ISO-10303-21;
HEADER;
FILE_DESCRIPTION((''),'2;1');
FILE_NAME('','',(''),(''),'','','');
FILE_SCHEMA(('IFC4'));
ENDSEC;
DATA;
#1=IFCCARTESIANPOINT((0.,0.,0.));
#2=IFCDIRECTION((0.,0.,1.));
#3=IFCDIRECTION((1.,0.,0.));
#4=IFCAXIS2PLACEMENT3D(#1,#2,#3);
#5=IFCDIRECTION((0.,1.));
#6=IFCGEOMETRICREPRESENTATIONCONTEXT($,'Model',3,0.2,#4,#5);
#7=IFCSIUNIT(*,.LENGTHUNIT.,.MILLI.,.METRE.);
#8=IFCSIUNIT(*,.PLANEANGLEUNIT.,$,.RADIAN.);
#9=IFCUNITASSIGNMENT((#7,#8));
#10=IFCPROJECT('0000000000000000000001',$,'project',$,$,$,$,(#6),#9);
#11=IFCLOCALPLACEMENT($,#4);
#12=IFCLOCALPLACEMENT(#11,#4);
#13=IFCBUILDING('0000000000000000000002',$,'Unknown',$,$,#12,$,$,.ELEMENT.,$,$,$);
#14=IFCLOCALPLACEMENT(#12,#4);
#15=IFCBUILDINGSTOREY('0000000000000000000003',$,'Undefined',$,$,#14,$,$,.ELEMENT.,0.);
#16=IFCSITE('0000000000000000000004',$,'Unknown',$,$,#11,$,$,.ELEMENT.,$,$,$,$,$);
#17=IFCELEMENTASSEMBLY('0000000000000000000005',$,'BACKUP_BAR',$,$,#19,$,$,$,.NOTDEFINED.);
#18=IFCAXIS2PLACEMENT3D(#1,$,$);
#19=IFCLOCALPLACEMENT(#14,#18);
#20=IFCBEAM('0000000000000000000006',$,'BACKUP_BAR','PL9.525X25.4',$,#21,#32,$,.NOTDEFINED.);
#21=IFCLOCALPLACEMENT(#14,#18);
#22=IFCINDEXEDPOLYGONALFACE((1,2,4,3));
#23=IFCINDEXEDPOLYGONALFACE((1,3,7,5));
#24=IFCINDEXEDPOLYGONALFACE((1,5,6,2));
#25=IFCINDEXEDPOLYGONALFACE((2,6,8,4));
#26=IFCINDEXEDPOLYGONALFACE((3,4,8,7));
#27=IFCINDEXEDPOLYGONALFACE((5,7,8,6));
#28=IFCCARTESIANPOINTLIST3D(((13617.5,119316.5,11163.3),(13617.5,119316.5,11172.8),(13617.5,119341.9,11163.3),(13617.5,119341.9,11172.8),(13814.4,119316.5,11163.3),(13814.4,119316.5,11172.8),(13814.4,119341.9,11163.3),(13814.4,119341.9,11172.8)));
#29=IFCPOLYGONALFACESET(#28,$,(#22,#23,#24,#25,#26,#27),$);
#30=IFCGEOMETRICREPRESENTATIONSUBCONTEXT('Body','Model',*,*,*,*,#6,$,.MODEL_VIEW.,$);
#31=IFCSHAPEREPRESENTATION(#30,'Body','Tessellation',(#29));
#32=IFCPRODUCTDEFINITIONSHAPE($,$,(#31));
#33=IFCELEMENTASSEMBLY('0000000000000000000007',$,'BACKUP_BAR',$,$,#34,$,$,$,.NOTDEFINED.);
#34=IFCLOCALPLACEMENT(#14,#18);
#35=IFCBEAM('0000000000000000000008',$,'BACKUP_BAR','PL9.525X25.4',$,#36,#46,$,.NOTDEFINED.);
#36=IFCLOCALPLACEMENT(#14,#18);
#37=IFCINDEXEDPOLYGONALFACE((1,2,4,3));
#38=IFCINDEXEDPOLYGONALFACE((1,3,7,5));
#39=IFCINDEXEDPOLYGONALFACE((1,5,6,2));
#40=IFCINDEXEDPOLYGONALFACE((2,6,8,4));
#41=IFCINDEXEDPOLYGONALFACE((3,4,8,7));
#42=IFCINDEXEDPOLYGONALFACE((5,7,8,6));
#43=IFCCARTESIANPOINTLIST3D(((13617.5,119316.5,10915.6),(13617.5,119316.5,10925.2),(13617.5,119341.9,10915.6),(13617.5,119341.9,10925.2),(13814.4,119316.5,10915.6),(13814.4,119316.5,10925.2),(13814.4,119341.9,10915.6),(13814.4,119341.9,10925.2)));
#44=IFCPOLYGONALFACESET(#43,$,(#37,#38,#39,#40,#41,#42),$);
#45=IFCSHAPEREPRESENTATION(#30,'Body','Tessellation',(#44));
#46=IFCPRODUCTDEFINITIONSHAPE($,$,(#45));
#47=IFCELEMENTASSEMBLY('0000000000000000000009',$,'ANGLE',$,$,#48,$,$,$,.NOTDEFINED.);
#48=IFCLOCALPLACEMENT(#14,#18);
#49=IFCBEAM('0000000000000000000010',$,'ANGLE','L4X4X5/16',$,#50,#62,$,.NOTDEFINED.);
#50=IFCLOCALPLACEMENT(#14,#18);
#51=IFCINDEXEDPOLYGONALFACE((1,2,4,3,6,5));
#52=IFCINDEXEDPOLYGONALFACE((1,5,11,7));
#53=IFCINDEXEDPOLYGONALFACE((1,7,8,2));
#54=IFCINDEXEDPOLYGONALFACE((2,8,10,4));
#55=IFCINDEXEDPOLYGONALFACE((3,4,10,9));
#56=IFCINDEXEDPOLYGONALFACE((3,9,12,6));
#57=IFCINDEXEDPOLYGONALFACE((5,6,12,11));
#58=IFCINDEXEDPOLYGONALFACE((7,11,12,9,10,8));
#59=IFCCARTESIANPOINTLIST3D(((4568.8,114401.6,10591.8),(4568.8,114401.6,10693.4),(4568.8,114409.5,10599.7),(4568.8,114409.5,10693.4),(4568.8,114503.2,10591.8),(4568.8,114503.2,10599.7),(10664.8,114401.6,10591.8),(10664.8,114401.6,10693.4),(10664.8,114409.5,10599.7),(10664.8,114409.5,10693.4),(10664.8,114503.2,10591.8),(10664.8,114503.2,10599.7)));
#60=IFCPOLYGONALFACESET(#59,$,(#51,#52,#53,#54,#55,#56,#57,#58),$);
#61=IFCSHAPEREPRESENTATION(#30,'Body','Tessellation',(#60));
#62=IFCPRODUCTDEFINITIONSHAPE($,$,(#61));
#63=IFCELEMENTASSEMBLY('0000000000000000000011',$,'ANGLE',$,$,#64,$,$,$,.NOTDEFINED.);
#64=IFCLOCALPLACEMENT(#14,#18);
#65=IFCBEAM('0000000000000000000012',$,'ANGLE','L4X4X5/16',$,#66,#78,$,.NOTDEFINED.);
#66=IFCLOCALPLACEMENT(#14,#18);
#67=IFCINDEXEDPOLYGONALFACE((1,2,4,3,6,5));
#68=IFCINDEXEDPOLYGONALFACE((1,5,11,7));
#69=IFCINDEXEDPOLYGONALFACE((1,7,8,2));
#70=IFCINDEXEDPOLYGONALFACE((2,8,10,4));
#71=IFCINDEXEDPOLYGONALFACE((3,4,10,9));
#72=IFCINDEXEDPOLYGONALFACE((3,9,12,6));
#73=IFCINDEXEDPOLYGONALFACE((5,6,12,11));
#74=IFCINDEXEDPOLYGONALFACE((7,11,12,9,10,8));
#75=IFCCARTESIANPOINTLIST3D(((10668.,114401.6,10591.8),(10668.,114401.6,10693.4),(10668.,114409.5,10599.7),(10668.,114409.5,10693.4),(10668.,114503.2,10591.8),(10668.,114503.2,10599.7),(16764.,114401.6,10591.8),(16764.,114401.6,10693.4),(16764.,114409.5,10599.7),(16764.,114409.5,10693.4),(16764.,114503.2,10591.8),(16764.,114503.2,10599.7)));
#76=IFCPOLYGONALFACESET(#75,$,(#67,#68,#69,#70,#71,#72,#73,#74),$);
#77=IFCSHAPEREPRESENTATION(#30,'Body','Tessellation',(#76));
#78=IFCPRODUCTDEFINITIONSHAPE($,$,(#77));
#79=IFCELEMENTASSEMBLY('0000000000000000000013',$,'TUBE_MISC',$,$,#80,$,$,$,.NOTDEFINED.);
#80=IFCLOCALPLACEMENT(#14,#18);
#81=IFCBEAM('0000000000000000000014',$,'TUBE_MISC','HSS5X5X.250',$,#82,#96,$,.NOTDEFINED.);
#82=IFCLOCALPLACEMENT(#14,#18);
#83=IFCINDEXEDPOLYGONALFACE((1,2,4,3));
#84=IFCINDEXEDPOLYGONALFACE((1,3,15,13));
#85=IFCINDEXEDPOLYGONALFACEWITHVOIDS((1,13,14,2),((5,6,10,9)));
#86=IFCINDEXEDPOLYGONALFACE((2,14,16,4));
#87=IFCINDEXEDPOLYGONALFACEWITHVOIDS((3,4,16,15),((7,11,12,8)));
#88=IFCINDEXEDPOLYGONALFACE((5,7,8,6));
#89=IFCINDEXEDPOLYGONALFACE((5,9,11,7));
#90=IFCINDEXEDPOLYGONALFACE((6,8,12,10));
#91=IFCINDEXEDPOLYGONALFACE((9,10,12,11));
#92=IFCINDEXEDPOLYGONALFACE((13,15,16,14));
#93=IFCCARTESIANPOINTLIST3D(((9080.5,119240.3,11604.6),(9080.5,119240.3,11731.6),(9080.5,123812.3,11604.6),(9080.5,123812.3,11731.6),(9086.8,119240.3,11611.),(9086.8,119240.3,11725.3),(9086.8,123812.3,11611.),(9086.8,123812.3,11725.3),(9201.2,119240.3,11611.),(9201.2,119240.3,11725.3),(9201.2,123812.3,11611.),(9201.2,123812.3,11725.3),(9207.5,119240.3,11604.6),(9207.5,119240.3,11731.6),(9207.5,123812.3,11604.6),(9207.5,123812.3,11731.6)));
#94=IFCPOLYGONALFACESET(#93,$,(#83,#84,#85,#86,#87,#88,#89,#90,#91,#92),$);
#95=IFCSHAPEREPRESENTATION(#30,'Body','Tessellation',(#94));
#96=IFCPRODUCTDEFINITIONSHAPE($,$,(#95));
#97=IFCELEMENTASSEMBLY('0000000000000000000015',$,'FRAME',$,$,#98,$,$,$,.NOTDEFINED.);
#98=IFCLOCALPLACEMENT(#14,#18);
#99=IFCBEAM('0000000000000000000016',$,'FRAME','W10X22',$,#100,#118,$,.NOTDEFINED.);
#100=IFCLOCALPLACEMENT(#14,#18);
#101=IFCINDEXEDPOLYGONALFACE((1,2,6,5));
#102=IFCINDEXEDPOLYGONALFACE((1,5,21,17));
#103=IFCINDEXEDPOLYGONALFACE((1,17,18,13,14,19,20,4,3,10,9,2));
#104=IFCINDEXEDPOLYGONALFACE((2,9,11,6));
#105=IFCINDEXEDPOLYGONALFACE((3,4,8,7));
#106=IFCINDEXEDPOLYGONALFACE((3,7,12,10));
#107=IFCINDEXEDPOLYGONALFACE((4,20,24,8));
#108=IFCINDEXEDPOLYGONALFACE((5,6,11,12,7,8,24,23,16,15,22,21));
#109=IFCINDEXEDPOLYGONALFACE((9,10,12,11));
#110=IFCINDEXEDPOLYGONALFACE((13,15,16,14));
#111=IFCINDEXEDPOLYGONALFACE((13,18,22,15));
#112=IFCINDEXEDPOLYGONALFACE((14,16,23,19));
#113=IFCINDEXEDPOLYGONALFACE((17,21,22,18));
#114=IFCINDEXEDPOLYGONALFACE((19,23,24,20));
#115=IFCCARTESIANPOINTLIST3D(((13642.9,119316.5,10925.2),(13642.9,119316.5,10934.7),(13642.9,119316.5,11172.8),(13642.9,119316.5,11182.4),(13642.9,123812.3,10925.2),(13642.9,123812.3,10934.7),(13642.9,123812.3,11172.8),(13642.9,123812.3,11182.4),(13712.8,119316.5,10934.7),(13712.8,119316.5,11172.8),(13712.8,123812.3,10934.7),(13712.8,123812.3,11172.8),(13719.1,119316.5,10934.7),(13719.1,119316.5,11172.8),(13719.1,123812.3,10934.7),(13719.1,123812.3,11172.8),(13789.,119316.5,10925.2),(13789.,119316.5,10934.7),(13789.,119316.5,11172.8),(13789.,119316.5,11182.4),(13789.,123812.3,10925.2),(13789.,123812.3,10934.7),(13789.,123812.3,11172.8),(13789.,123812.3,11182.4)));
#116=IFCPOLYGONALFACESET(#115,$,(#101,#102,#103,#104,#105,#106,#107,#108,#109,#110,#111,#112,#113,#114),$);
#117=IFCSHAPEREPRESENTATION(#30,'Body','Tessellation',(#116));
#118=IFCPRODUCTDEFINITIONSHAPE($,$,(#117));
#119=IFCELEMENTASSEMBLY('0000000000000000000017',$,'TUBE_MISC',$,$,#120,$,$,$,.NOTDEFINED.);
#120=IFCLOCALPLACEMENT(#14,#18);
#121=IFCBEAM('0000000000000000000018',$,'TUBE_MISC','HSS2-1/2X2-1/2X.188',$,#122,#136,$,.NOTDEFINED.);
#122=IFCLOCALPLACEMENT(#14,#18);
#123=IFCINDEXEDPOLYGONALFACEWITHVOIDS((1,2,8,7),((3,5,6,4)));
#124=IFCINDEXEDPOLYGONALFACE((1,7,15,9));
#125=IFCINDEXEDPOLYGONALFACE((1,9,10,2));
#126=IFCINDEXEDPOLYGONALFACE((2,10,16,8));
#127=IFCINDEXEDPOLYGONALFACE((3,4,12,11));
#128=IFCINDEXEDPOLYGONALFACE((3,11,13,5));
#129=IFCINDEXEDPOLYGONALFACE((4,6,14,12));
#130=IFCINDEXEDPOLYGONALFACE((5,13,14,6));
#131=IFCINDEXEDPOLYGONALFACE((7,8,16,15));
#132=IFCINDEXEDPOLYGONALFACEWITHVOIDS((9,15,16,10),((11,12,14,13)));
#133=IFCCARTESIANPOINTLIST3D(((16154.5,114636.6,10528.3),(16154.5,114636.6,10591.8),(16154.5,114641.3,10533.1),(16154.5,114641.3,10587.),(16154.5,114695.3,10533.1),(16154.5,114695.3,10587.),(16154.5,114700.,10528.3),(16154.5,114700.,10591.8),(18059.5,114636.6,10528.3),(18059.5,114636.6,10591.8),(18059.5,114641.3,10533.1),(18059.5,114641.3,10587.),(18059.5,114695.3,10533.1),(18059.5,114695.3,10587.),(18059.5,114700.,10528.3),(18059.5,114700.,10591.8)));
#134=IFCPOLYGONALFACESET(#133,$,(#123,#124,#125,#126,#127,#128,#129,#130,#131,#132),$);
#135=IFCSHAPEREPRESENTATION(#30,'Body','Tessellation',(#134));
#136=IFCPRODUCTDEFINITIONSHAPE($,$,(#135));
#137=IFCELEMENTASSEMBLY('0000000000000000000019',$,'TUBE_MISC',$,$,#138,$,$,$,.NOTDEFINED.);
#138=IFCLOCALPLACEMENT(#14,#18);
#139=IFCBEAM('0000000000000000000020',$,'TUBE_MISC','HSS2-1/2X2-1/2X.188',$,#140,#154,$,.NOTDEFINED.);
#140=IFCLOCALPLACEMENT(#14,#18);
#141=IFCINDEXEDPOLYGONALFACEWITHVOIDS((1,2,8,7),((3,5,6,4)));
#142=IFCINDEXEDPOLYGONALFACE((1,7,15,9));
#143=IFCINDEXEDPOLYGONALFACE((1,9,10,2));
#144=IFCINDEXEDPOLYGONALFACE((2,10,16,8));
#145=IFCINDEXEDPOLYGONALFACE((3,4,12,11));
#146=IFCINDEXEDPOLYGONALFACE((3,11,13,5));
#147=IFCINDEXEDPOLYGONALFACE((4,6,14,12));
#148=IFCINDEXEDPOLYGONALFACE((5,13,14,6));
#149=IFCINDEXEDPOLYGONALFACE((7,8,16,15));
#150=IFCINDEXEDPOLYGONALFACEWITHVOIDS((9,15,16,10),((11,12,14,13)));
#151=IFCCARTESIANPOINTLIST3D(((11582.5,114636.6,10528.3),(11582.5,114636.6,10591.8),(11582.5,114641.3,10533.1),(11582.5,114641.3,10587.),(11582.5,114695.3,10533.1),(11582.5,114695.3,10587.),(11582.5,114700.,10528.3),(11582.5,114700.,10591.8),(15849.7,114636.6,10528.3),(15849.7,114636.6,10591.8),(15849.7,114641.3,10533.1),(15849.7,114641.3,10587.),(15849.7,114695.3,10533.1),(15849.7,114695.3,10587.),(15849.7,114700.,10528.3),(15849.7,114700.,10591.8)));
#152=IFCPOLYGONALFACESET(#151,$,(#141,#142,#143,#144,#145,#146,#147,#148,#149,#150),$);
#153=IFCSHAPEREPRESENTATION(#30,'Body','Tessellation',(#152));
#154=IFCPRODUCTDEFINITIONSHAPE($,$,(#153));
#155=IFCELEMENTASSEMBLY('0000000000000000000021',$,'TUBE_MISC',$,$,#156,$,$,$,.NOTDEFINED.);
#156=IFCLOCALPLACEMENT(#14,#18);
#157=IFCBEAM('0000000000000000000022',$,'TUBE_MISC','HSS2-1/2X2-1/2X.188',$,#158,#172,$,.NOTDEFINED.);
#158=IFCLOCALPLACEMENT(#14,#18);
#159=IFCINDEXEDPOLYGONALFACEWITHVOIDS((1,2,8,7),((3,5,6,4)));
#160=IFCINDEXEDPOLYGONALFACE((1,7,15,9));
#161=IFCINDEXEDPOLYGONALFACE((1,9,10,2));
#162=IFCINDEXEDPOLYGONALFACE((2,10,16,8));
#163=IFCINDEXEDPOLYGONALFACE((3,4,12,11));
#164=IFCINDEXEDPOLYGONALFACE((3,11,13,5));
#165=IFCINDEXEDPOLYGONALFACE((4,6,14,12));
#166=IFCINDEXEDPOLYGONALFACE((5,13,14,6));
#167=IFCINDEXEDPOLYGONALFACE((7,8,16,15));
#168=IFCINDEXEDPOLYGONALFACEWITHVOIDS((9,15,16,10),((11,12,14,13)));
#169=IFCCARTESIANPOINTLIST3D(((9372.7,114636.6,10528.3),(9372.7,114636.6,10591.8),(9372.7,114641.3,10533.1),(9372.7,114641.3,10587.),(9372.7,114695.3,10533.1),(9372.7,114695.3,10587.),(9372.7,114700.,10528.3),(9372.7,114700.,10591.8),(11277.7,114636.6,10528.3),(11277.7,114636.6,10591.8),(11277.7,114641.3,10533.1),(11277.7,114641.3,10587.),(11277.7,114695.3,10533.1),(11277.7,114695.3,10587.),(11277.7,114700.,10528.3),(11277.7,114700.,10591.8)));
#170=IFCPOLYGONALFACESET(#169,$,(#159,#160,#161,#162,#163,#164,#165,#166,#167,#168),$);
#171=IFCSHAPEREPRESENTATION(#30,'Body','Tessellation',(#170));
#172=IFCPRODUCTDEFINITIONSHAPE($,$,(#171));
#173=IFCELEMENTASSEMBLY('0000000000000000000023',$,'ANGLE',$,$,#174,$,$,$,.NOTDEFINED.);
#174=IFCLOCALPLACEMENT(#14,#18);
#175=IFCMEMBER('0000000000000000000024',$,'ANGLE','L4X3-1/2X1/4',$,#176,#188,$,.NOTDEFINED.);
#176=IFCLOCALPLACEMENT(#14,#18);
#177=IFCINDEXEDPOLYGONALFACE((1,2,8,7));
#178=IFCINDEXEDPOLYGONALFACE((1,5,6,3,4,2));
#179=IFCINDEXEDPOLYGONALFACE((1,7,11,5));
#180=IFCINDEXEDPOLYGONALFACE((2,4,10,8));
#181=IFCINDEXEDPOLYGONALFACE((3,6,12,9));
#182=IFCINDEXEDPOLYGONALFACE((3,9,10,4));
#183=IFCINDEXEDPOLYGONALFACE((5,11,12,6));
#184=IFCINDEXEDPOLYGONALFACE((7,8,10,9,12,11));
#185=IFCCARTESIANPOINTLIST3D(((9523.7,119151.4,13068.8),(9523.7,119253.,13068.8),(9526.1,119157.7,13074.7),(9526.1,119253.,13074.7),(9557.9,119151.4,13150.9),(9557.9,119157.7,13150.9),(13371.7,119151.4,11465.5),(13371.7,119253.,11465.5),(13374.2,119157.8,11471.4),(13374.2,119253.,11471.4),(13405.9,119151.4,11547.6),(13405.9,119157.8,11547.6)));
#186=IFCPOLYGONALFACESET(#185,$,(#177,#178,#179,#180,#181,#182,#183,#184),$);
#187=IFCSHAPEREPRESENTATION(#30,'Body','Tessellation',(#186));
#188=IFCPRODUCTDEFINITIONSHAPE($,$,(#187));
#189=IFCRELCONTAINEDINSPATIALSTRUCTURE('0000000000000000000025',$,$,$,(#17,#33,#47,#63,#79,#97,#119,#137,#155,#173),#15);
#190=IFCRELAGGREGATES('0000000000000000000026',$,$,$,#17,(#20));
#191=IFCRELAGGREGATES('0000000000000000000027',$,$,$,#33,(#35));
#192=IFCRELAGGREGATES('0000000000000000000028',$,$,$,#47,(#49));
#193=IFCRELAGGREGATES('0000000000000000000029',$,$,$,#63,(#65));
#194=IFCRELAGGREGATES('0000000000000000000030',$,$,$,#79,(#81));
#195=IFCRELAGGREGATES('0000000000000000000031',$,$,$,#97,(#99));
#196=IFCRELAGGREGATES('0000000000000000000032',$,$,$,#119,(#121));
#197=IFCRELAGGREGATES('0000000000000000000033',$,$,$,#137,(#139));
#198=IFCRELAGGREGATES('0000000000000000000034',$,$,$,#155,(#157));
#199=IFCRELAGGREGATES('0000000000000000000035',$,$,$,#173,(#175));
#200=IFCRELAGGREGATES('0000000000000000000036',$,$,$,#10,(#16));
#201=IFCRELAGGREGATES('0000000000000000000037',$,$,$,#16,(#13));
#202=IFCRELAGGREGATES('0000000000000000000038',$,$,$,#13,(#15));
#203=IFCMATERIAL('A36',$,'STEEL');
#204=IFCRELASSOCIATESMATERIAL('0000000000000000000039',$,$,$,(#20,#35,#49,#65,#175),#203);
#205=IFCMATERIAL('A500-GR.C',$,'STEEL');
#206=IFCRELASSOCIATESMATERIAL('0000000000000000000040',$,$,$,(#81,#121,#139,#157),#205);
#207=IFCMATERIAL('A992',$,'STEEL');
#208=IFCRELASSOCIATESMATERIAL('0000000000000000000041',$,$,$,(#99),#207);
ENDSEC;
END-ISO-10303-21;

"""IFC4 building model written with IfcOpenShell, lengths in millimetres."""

from ifc_helpers import new_model, si_unit, direction, frame, origin_with_axes, place, context, subcontext, project, spatial, line, indexed_curve, outline, extrude, material, element, aggregate, save


model = new_model("IFC4")

# Units and contexts
model_context = context("Model", 3, precision=0.2, world=origin_with_axes(), true_north=direction((0.0, 1.0)))
body_context = subcontext(model_context, "Body", "Model", "MODEL_VIEW")
ifc_project = project(units=[si_unit("LENGTHUNIT", "METRE", prefix="MILLI"), si_unit("PLANEANGLEUNIT", "RADIAN")], contexts=[model_context])

# Site, building, storey
site_placement = place(None, origin_with_axes())
site = spatial("IfcSite", under=ifc_project, at=site_placement, Name="Unknown", CompositionType="ELEMENT")
building_placement = place(site_placement, origin_with_axes())
building = spatial("IfcBuilding", under=site, at=building_placement, Name="Unknown", CompositionType="ELEMENT")
storey_placement = place(building_placement, origin_with_axes())
storey = spatial("IfcBuildingStorey", under=building, at=storey_placement, Name="Undefined", CompositionType="ELEMENT", Elevation=0.0)

# Shared definitions
ifc_material_1 = material(Name="A500-GR.C", Category="STEEL")

# Shared definitions
ifc_material_2 = material(Name="A992", Category="STEEL")

# Shared definitions
ifc_material_3 = material(Name="A36", Category="STEEL")

# Element assemblies, beams
assembly_1_placement = place(storey_placement, frame((13617.5, 119329.2, 11168.1), z_axis=(0.0, 0.0, 1.0), x_axis=(1.0, 0.0, 0.0)))
assembly_1 = element("IfcElementAssembly", 1, at=assembly_1_placement, inside=storey, Name="BACKUP_BAR", PredefinedType="NOTDEFINED")
beam_1_placement = place(assembly_1_placement, origin_with_axes())
beam_1 = element("IfcBeam", 2, at=beam_1_placement, material=ifc_material_3, Name="BACKUP_BAR", Description="PL9.525X25.4", PredefinedType="NOTDEFINED", context=body_context, shape_type="SolidModel", body=[
    extrude(outline(indexed_curve([(-4.8, -12.7), (4.8, -12.7), (4.8, 12.7), (-4.8, 12.7)], segments=[line(1, 2, 3, 4, 1)])), frame((0.0, 0.0, 0.0), z_axis=(-1.0, 0.0, 0.0), x_axis=(0.0, 0.0, 1.0)), (0.0, 0.0, -1.0), 196.8),
])
aggregate(assembly_1, [beam_1])
assembly_2_placement = place(storey_placement, frame((13617.5, 119329.2, 10920.4), z_axis=(0.0, 0.0, 1.0), x_axis=(1.0, 0.0, 0.0)))
assembly_2 = element("IfcElementAssembly", 3, at=assembly_2_placement, inside=storey, Name="BACKUP_BAR", PredefinedType="NOTDEFINED")
beam_2_placement = place(assembly_2_placement, origin_with_axes())
beam_2 = element("IfcBeam", 4, at=beam_2_placement, material=ifc_material_3, Name="BACKUP_BAR", Description="PL9.525X25.4", PredefinedType="NOTDEFINED", context=body_context, shape_type="SolidModel", body=[
    extrude(outline(indexed_curve([(-4.8, -12.7), (4.8, -12.7), (4.8, 12.7), (-4.8, 12.7)], segments=[line(1, 2, 3, 4, 1)])), frame((0.0, 0.0, 0.0), z_axis=(-1.0, 0.0, 0.0), x_axis=(0.0, 0.0, 1.0)), (0.0, 0.0, -1.0), 196.8),
])
aggregate(assembly_2, [beam_2])
assembly_3_placement = place(storey_placement, frame((10664.8, 114452.4, 10642.6), z_axis=(0.0, 1.0, 0.0), x_axis=(-1.0, 0.0, 0.0)))
assembly_3 = element("IfcElementAssembly", 5, at=assembly_3_placement, inside=storey, Name="ANGLE", PredefinedType="NOTDEFINED")
beam_3_placement = place(assembly_3_placement, origin_with_axes())
beam_3 = element("IfcBeam", 6, at=beam_3_placement, material=ifc_material_3, Name="ANGLE", Description="L4X4X5/16", PredefinedType="NOTDEFINED", context=body_context, shape_type="SolidModel", body=[
    extrude(outline(indexed_curve([(-50.8, -50.8), (50.8, -50.8), (50.8, -42.9), (-42.9, -42.9), (-42.9, 50.8), (-50.8, 50.8)], segments=[line(1, 2, 3, 4, 5, 6, 1)])), frame((0.0, 0.0, 0.0), z_axis=(-1.0, 0.0, 0.0), x_axis=(0.0, 0.0, 1.0)), (0.0, 0.0, -1.0), 6096.0),
])
aggregate(assembly_3, [beam_3])
assembly_4_placement = place(storey_placement, frame((16764.0, 114452.4, 10642.6), z_axis=(0.0, 1.0, 0.0), x_axis=(-1.0, 0.0, 0.0)))
assembly_4 = element("IfcElementAssembly", 7, at=assembly_4_placement, inside=storey, Name="ANGLE", PredefinedType="NOTDEFINED")
beam_4_placement = place(assembly_4_placement, origin_with_axes())
beam_4 = element("IfcBeam", 8, at=beam_4_placement, material=ifc_material_3, Name="ANGLE", Description="L4X4X5/16", PredefinedType="NOTDEFINED", context=body_context, shape_type="SolidModel", body=[
    extrude(outline(indexed_curve([(-50.8, -50.8), (50.8, -50.8), (50.8, -42.9), (-42.9, -42.9), (-42.9, 50.8), (-50.8, 50.8)], segments=[line(1, 2, 3, 4, 5, 6, 1)])), frame((0.0, 0.0, 0.0), z_axis=(-1.0, 0.0, 0.0), x_axis=(0.0, 0.0, 1.0)), (0.0, 0.0, -1.0), 6096.0),
])
aggregate(assembly_4, [beam_4])
assembly_5_placement = place(storey_placement, frame((9144.0, 119240.3, 11668.1), z_axis=(1.0, 0.0, 0.0), x_axis=(0.0, 1.0, 0.0)))
assembly_5 = element("IfcElementAssembly", 9, at=assembly_5_placement, inside=storey, Name="TUBE_MISC", PredefinedType="NOTDEFINED")
beam_5_placement = place(assembly_5_placement, origin_with_axes())
beam_5 = element("IfcBeam", 10, at=beam_5_placement, material=ifc_material_1, Name="TUBE_MISC", Description="HSS5X5X.250", PredefinedType="NOTDEFINED", context=body_context, shape_type="SolidModel", body=[
    extrude(outline(indexed_curve([(-63.5, -63.5), (63.5, -63.5), (63.5, 63.5), (-63.5, 63.5)], segments=[line(1, 2, 3, 4, 1)]), holes=[indexed_curve([(-57.1, -57.1), (-57.1, 57.1), (57.1, 57.1), (57.1, -57.1)], segments=[line(1, 2, 3, 4, 1)])]), frame((0.0, 0.0, 0.0), z_axis=(-1.0, 0.0, 0.0), x_axis=(0.0, 0.0, 1.0)), (0.0, 0.0, -1.0), 4572.0),
])
aggregate(assembly_5, [beam_5])
assembly_6_placement = place(storey_placement, frame((13716.0, 119316.5, 11053.8), z_axis=(1.0, 0.0, 0.0), x_axis=(0.0, 1.0, 0.0)))
assembly_6 = element("IfcElementAssembly", 11, at=assembly_6_placement, inside=storey, Name="FRAME", PredefinedType="NOTDEFINED")
beam_6_placement = place(assembly_6_placement, origin_with_axes())
beam_6 = element("IfcBeam", 12, at=beam_6_placement, material=ifc_material_2, Name="FRAME", Description="W10X22", PredefinedType="NOTDEFINED", context=body_context, shape_type="SolidModel", body=[
    extrude(outline(indexed_curve([(-73.0, -128.6), (73.0, -128.6), (73.0, -119.1), (3.2, -119.1), (3.2, 119.1), (73.0, 119.1), (73.0, 128.6), (-73.0, 128.6), (-73.0, 119.1), (-3.2, 119.1), (-3.2, -119.1), (-73.0, -119.1)], segments=[line(1, 2, 3, 4, 5, 6, 7, 8, 9, 10, 11, 12, 1)])), frame((0.0, 0.0, 0.0), z_axis=(-1.0, 0.0, 0.0), x_axis=(0.0, 0.0, 1.0)), (0.0, 0.0, -1.0), 4495.8),
])
aggregate(assembly_6, [beam_6])
assembly_7_placement = place(storey_placement, frame((16154.5, 114668.3, 10560.0), z_axis=(0.0, -1.0, 0.0), x_axis=(1.0, 0.0, 0.0)))
assembly_7 = element("IfcElementAssembly", 13, at=assembly_7_placement, inside=storey, Name="TUBE_MISC", PredefinedType="NOTDEFINED")
beam_7_placement = place(assembly_7_placement, origin_with_axes())
beam_7 = element("IfcBeam", 14, at=beam_7_placement, material=ifc_material_1, Name="TUBE_MISC", Description="HSS2-1/2X2-1/2X.188", PredefinedType="NOTDEFINED", context=body_context, shape_type="SolidModel", body=[
    extrude(outline(indexed_curve([(-31.8, -31.8), (31.8, -31.8), (31.8, 31.8), (-31.8, 31.8)], segments=[line(1, 2, 3, 4, 1)]), holes=[indexed_curve([(-27.0, -27.0), (-27.0, 27.0), (27.0, 27.0), (27.0, -27.0)], segments=[line(1, 2, 3, 4, 1)])]), frame((0.0, 0.0, 0.0), z_axis=(-1.0, 0.0, 0.0), x_axis=(0.0, 0.0, 1.0)), (0.0, 0.0, -1.0), 1905.0),
])
aggregate(assembly_7, [beam_7])
assembly_8_placement = place(storey_placement, frame((11582.5, 114668.3, 10560.0), z_axis=(0.0, -1.0, 0.0), x_axis=(1.0, 0.0, 0.0)))
assembly_8 = element("IfcElementAssembly", 15, at=assembly_8_placement, inside=storey, Name="TUBE_MISC", PredefinedType="NOTDEFINED")
beam_8_placement = place(assembly_8_placement, origin_with_axes())
beam_8 = element("IfcBeam", 16, at=beam_8_placement, material=ifc_material_1, Name="TUBE_MISC", Description="HSS2-1/2X2-1/2X.188", PredefinedType="NOTDEFINED", context=body_context, shape_type="SolidModel", body=[
    extrude(outline(indexed_curve([(-31.8, -31.8), (31.8, -31.8), (31.8, 31.8), (-31.8, 31.8)], segments=[line(1, 2, 3, 4, 1)]), holes=[indexed_curve([(-27.0, -27.0), (-27.0, 27.0), (27.0, 27.0), (27.0, -27.0)], segments=[line(1, 2, 3, 4, 1)])]), frame((0.0, 0.0, 0.0), z_axis=(-1.0, 0.0, 0.0), x_axis=(0.0, 0.0, 1.0)), (0.0, 0.0, -1.0), 4267.2),
])
aggregate(assembly_8, [beam_8])
assembly_9_placement = place(storey_placement, frame((9372.7, 114668.3, 10560.0), z_axis=(0.0, -1.0, 0.0), x_axis=(1.0, 0.0, 0.0)))
assembly_9 = element("IfcElementAssembly", 17, at=assembly_9_placement, inside=storey, Name="TUBE_MISC", PredefinedType="NOTDEFINED")
beam_9_placement = place(assembly_9_placement, origin_with_axes())
beam_9 = element("IfcBeam", 18, at=beam_9_placement, material=ifc_material_1, Name="TUBE_MISC", Description="HSS2-1/2X2-1/2X.188", PredefinedType="NOTDEFINED", context=body_context, shape_type="SolidModel", body=[
    extrude(outline(indexed_curve([(-31.8, -31.8), (31.8, -31.8), (31.8, 31.8), (-31.8, 31.8)], segments=[line(1, 2, 3, 4, 1)]), holes=[indexed_curve([(-27.0, -27.0), (-27.0, 27.0), (27.0, 27.0), (27.0, -27.0)], segments=[line(1, 2, 3, 4, 1)])]), frame((0.0, 0.0, 0.0), z_axis=(-1.0, 0.0, 0.0), x_axis=(0.0, 0.0, 1.0)), (0.0, 0.0, -1.0), 1905.0),
])
aggregate(assembly_9, [beam_9])

# Element assembly, member
assembly_10_placement = place(storey_placement, frame((9540.8, 119202.2, 13109.9), z_axis=(0.384615, 0.000001, 0.923077), x_axis=(0.923077, 0.000001, -0.384615)))
assembly_10 = element("IfcElementAssembly", 19, at=assembly_10_placement, inside=storey, Name="ANGLE", PredefinedType="NOTDEFINED")
member_1_placement = place(assembly_10_placement, origin_with_axes())
member_1 = element("IfcMember", 20, at=member_1_placement, material=ifc_material_3, Name="ANGLE", Description="L4X3-1/2X1/4", PredefinedType="NOTDEFINED", context=body_context, shape_type="SolidModel", body=[
    extrude(outline(indexed_curve([(-44.5, -50.8), (44.5, -50.8), (44.5, -44.5), (-38.1, -44.5), (-38.1, 50.8), (-44.5, 50.8)], segments=[line(1, 2, 3, 4, 5, 6, 1)])), frame((0.0, 0.0, 0.0), z_axis=(-1.0, 0.0, 0.0), x_axis=(0.0, 0.0, 1.0)), (0.0, 0.0, -1.0), 4168.7),
])
aggregate(assembly_10, [member_1])

save(model, "model.ifc")
